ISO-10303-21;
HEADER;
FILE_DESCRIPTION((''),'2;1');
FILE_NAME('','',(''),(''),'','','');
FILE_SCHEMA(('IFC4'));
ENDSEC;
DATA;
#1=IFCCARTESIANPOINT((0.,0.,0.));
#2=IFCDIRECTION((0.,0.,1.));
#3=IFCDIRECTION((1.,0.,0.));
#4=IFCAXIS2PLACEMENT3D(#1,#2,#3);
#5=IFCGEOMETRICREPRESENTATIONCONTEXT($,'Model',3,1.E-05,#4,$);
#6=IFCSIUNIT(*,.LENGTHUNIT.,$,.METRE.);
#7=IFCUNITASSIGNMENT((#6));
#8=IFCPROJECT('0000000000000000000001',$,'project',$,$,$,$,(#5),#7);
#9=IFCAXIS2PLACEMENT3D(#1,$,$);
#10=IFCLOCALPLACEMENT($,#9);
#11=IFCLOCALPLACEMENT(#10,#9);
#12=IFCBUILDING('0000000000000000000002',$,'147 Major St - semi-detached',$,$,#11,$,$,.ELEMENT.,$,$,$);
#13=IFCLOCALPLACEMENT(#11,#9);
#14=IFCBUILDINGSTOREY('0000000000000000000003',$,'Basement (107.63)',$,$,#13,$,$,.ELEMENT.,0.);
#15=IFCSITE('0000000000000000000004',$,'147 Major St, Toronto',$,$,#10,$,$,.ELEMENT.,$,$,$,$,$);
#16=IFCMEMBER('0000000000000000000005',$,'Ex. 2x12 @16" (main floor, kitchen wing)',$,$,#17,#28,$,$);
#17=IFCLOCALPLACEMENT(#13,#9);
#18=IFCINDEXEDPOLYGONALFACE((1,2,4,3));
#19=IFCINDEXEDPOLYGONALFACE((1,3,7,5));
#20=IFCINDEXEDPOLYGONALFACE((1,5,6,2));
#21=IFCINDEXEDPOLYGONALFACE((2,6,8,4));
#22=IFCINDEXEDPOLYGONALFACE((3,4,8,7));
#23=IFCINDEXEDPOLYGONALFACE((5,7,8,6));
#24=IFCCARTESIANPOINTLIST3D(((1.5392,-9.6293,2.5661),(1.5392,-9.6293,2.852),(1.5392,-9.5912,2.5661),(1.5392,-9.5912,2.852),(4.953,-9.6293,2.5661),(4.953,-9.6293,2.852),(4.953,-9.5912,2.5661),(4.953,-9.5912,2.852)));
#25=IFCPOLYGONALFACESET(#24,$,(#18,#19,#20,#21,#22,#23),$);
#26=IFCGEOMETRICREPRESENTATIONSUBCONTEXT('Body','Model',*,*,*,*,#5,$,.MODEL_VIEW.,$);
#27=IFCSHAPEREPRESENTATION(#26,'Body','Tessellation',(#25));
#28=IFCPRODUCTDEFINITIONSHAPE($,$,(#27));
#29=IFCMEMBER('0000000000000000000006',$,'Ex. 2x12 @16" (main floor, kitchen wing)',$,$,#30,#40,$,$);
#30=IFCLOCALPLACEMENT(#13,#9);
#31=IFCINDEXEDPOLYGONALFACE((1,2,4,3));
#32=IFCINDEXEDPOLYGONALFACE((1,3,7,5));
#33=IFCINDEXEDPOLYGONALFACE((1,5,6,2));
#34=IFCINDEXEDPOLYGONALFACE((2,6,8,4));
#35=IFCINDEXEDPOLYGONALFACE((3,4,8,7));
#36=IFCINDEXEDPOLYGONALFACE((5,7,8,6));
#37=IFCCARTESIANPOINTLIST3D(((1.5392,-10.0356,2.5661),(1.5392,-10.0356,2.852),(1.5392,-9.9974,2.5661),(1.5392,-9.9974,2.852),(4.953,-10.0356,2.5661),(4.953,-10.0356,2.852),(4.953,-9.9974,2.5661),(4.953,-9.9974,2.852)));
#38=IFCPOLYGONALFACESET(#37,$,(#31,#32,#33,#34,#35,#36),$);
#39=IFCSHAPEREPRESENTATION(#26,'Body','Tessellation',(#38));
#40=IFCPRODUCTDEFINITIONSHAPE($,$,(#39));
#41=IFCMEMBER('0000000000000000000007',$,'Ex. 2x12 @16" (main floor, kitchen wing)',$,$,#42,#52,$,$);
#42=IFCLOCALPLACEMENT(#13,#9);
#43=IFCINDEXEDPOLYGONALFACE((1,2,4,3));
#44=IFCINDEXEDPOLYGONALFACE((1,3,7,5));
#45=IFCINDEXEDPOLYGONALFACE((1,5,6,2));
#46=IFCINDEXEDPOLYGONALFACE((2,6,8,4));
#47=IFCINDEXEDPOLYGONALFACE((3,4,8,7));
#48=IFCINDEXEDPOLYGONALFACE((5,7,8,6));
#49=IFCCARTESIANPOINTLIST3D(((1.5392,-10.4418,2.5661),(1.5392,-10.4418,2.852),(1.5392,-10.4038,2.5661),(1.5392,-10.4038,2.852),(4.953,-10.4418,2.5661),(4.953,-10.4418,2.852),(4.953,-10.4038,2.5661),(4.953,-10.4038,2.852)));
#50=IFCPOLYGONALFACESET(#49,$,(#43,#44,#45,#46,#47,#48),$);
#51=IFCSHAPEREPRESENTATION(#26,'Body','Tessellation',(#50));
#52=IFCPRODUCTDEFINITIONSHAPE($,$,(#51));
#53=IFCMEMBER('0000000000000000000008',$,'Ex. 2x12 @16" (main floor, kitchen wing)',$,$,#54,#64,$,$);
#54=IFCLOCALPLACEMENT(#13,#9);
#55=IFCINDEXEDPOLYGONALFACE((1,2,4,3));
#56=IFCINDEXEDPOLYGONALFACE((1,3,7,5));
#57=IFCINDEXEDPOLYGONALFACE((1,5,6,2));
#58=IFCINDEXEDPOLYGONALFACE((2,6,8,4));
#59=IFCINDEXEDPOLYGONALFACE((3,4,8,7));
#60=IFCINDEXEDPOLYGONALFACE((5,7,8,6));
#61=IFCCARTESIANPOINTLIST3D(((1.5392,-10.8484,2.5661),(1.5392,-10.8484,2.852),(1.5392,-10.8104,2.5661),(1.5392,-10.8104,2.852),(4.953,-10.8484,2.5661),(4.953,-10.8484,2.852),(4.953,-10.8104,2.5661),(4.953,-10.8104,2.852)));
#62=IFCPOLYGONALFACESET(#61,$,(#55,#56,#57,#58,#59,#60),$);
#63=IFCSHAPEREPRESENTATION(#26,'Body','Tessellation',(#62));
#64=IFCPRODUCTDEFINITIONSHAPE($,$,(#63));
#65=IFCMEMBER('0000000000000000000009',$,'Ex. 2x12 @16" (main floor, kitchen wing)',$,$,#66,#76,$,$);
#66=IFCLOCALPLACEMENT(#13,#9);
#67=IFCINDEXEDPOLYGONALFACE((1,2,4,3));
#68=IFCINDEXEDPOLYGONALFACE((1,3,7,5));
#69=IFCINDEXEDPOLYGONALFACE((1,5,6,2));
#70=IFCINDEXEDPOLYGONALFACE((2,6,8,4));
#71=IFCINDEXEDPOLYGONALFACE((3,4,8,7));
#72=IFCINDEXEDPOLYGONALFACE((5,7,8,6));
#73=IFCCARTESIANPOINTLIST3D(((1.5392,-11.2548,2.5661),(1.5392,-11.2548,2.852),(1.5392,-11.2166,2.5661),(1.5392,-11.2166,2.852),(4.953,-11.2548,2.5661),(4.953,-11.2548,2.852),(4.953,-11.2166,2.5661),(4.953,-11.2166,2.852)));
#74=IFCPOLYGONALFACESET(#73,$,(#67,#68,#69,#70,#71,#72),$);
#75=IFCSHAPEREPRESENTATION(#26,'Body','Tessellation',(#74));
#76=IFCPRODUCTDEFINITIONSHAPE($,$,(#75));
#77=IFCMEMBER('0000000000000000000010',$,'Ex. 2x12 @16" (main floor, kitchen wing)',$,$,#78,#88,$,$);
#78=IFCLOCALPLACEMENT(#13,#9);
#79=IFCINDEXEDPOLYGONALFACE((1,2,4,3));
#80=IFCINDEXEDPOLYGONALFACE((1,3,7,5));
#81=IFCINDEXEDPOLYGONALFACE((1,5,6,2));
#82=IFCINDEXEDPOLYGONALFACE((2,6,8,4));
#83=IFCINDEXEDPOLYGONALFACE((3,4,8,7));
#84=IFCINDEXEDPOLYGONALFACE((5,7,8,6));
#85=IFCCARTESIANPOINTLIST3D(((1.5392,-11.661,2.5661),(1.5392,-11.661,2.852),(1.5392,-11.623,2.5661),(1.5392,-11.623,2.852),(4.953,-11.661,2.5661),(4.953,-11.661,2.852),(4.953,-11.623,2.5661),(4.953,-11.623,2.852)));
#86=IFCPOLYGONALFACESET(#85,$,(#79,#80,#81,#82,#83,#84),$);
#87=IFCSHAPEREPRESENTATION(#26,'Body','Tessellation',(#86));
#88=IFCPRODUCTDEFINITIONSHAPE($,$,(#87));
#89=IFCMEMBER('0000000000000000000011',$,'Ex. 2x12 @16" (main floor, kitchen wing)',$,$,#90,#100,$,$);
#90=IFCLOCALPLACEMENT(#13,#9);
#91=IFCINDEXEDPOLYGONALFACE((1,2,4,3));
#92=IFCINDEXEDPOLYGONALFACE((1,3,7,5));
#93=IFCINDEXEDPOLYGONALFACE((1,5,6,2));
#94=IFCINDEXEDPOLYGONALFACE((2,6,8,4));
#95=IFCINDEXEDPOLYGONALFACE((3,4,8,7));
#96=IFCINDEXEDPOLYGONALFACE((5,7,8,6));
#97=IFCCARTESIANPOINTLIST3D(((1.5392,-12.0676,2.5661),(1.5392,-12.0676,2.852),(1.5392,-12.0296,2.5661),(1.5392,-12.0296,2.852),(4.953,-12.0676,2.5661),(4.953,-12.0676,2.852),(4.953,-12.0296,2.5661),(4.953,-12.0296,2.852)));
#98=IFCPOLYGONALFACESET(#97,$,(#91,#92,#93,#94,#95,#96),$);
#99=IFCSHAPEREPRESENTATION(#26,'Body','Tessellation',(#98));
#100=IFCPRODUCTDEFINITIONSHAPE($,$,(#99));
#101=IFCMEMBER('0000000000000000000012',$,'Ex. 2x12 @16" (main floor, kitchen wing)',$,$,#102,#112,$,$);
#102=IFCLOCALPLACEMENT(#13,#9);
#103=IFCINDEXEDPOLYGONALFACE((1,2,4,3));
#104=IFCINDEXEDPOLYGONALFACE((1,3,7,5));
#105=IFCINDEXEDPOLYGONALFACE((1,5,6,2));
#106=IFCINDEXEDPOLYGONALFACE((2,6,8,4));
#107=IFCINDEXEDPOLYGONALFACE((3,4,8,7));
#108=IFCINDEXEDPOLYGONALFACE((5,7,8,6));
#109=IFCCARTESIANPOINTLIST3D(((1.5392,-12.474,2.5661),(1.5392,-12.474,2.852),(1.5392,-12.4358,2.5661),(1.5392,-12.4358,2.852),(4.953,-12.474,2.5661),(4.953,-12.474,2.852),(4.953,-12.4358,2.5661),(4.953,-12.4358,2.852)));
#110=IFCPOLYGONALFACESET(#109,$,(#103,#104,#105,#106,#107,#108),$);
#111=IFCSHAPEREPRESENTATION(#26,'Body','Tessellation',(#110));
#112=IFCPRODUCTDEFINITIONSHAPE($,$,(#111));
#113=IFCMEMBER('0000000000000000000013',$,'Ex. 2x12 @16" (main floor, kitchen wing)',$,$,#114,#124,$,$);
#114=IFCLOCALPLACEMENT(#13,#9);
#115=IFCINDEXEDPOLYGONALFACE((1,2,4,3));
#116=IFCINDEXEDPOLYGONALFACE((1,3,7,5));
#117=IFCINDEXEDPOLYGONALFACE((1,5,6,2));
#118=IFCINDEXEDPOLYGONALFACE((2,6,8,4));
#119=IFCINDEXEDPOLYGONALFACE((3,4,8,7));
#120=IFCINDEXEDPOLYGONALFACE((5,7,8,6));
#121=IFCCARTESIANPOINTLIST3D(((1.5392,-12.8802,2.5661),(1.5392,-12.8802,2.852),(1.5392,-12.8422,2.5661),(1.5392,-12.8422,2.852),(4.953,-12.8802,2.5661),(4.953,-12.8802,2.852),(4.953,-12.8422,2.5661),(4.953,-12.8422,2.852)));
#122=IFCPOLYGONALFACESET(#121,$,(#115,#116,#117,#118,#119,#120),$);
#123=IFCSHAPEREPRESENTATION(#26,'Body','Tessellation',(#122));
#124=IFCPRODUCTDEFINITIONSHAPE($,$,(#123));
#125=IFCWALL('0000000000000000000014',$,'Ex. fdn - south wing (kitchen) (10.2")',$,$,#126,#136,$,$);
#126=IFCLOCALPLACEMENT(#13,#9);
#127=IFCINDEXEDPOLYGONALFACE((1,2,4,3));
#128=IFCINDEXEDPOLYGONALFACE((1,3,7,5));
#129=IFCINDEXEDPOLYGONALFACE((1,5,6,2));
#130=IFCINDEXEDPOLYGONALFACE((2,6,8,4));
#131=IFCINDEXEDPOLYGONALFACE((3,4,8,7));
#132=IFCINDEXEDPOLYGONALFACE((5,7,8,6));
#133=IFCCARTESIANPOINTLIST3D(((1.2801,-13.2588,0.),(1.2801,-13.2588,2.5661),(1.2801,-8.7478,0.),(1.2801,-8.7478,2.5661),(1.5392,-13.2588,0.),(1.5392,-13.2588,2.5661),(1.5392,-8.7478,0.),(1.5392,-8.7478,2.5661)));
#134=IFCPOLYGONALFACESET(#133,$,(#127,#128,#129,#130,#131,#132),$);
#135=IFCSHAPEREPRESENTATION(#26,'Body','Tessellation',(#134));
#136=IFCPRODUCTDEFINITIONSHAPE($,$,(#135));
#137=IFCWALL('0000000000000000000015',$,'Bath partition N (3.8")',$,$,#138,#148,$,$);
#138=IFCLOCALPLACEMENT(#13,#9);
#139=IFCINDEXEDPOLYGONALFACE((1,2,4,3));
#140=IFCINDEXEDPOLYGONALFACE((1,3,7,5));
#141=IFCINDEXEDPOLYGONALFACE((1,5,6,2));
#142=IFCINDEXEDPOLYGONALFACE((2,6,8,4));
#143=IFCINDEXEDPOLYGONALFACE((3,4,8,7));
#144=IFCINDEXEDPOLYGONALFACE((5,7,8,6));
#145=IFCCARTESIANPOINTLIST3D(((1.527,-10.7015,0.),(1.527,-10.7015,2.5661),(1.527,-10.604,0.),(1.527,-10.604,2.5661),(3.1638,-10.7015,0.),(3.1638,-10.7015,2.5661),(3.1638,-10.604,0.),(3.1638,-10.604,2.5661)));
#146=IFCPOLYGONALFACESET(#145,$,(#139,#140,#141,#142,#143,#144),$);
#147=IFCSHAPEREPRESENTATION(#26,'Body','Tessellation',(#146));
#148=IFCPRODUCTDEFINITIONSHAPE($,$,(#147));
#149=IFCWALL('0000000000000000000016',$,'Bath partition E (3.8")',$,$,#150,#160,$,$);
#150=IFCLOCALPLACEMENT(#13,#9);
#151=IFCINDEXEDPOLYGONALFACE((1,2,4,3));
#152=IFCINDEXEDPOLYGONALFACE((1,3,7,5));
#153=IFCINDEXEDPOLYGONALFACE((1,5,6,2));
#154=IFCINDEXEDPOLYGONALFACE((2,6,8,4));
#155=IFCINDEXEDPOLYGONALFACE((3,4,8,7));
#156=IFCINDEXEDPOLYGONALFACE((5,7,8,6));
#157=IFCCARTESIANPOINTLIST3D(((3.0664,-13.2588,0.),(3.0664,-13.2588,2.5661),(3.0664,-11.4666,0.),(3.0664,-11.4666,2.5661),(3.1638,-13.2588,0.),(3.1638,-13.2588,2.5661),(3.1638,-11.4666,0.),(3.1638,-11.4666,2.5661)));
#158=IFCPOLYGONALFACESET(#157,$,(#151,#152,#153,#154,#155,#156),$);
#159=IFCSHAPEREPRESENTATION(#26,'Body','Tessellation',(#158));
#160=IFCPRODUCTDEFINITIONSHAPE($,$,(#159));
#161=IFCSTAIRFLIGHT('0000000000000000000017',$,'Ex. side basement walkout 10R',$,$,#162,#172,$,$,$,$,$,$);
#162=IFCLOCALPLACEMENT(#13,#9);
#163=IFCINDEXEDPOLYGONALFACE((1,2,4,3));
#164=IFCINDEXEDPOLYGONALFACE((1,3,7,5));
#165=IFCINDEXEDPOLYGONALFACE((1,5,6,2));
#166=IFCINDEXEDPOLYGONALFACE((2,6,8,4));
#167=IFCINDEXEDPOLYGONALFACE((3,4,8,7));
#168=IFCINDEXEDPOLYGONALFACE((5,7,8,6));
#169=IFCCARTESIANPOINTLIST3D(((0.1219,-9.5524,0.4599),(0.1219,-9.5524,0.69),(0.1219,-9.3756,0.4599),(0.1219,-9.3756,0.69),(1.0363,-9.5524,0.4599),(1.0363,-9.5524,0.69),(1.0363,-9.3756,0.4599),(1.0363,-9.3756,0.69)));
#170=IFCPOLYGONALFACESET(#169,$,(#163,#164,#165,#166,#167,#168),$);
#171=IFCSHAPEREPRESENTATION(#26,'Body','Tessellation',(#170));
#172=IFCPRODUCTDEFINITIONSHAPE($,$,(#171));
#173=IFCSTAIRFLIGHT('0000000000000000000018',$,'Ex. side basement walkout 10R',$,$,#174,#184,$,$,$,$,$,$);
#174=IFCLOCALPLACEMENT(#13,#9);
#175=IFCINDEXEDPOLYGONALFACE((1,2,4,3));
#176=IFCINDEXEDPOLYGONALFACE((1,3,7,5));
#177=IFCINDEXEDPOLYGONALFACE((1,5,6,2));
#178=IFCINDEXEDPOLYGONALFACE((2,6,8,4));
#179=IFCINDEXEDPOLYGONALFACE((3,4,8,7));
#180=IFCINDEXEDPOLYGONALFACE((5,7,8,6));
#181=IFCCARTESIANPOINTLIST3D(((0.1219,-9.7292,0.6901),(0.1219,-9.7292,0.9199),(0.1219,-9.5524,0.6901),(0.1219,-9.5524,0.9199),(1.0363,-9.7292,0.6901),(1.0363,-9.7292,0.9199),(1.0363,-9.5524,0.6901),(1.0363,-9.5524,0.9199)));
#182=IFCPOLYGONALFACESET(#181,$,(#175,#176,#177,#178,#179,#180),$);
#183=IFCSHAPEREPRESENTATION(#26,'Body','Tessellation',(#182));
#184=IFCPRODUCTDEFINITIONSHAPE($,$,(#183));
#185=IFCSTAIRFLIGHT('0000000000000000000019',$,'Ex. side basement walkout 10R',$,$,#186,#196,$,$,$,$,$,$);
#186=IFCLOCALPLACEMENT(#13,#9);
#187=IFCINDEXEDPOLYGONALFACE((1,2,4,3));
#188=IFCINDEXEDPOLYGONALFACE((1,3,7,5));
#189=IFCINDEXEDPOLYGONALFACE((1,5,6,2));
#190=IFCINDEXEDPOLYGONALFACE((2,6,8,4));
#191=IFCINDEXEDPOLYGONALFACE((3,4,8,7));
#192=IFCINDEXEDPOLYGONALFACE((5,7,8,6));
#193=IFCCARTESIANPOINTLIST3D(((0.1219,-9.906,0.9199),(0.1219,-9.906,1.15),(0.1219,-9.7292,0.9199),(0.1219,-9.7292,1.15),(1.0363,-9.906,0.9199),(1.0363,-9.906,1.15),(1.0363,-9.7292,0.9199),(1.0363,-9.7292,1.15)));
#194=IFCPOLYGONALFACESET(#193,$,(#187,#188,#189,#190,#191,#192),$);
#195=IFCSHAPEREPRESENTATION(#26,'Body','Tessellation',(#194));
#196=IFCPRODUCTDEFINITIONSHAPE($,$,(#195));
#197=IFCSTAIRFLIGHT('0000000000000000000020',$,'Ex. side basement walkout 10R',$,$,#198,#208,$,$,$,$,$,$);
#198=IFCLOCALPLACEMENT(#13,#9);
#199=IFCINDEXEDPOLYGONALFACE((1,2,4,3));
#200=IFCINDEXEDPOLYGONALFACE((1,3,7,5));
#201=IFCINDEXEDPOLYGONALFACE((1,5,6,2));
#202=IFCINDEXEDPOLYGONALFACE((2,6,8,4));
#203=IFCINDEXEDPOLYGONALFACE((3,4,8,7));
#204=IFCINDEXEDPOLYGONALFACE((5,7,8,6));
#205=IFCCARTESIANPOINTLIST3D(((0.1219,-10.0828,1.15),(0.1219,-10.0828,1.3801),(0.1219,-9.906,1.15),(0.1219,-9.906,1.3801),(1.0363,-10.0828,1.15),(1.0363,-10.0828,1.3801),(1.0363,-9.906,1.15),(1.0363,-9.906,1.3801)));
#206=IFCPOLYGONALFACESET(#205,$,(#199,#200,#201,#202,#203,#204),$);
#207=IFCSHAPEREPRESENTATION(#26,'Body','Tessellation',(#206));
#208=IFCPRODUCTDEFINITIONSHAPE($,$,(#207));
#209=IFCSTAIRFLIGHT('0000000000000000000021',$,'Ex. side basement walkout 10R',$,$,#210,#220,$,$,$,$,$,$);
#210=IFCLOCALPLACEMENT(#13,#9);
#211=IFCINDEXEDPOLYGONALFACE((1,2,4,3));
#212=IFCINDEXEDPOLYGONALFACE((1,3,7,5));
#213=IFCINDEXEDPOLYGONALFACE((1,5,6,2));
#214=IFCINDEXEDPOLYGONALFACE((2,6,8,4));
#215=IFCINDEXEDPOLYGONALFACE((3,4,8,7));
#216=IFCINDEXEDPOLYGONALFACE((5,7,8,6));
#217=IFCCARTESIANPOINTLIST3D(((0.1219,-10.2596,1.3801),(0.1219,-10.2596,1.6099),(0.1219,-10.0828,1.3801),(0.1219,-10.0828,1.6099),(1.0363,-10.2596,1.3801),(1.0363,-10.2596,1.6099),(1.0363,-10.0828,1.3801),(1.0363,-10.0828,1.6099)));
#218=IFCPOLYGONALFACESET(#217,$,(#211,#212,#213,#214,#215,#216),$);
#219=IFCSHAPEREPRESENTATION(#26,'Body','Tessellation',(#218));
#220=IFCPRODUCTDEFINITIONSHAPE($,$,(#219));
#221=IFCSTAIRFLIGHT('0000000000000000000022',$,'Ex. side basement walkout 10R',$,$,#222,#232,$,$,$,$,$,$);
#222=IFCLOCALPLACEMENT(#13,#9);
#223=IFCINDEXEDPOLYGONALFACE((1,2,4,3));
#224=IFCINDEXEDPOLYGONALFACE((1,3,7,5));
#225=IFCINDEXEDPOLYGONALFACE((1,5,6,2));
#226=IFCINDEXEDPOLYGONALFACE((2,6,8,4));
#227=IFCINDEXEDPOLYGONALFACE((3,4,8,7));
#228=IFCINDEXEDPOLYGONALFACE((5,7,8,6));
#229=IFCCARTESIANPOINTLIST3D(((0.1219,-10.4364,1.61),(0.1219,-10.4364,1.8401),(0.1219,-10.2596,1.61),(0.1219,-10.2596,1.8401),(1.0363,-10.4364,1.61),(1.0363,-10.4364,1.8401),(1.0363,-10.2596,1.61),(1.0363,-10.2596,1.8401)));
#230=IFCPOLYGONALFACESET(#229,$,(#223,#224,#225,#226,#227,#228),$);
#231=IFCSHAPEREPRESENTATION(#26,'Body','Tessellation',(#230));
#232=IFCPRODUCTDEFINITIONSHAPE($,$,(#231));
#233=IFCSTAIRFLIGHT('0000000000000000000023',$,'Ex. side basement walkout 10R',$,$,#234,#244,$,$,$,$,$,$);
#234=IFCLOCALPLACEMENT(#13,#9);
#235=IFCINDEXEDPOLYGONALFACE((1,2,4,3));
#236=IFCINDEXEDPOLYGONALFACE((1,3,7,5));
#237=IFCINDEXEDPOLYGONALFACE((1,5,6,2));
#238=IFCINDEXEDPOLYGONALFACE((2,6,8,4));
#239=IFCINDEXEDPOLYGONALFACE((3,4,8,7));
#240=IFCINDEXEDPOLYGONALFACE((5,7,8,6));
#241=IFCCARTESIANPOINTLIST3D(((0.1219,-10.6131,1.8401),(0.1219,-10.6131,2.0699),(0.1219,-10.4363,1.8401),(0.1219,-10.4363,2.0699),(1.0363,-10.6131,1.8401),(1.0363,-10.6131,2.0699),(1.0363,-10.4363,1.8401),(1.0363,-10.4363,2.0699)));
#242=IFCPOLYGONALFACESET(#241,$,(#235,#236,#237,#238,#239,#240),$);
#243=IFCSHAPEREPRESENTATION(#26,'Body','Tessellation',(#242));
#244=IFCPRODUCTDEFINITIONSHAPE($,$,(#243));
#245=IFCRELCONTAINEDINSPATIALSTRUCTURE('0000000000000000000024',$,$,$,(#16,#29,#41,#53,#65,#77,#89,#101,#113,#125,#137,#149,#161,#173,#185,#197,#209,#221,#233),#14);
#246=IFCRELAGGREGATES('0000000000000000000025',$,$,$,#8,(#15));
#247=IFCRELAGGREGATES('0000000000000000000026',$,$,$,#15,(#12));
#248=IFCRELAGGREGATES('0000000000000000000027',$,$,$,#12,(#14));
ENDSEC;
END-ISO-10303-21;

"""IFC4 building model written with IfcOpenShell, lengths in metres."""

from ifc_helpers import new_model, si_unit, frame, origin, origin_with_axes, place, context, subcontext, project, spatial, rectangle, extrude, element, save


model = new_model("IFC4")

# Units and contexts
model_context = context("Model", 3, precision=1e-05, world=origin_with_axes())
body_context = subcontext(model_context, "Body", "Model", "MODEL_VIEW")
ifc_project = project(units=[si_unit("LENGTHUNIT", "METRE")], contexts=[model_context])

# Site, building, storey
site_placement = place(None, origin())
site = spatial("IfcSite", under=ifc_project, at=site_placement, Name="147 Major St, Toronto", CompositionType="ELEMENT")
building_placement = place(site_placement, origin())
building = spatial("IfcBuilding", under=site, at=building_placement, Name="147 Major St - semi-detached", CompositionType="ELEMENT")
storey_placement = place(building_placement, origin())
storey = spatial("IfcBuildingStorey", under=building, at=storey_placement, Name="Basement (107.63)", CompositionType="ELEMENT", Elevation=0.0)

# Members
for number, where, name in (
    (1, (3.2461, -9.6102, 2.5661), "Ex. 2x12 @16\" (main floor, kitchen wing)"),
    (2, (3.2461, -10.0165, 2.5661), "Ex. 2x12 @16\" (main floor, kitchen wing)"),
    (3, (3.2461, -10.4228, 2.5661), "Ex. 2x12 @16\" (main floor, kitchen wing)"),
    (4, (3.2461, -10.8294, 2.5661), "Ex. 2x12 @16\" (main floor, kitchen wing)"),
    (5, (3.2461, -11.2357, 2.5661), "Ex. 2x12 @16\" (main floor, kitchen wing)"),
    (6, (3.2461, -11.642, 2.5661), "Ex. 2x12 @16\" (main floor, kitchen wing)"),
    (7, (3.2461, -12.0486, 2.5661), "Ex. 2x12 @16\" (main floor, kitchen wing)"),
    (8, (3.2461, -12.4549, 2.5661), "Ex. 2x12 @16\" (main floor, kitchen wing)"),
    (9, (3.2461, -12.8612, 2.5661), "Ex. 2x12 @16\" (main floor, kitchen wing)"),
):
    element("IfcMember", number, at=place(storey_placement, frame(where)), inside=storey, Name=name, context=body_context, shape_type="SweptSolid", body=[
        extrude(rectangle(XDim=3.4138, YDim=0.0381), origin_with_axes(), (0.0, 0.0, 1.0), 0.2859),
    ])

# Walls
wall_1_placement = place(storey_placement, frame((1.4097, -11.0033, 0.0)))
element("IfcWall", 10, at=wall_1_placement, inside=storey, Name="Ex. fdn - south wing (kitchen) (10.2\")", context=body_context, shape_type="SweptSolid", body=[
    extrude(rectangle(XDim=0.2591, YDim=4.511), origin_with_axes(), (0.0, 0.0, 1.0), 2.5661),
])
wall_2_placement = place(storey_placement, frame((2.3454, -10.6528, 0.0)))
element("IfcWall", 11, at=wall_2_placement, inside=storey, Name="Bath partition N (3.8\")", context=body_context, shape_type="SweptSolid", body=[
    extrude(rectangle(XDim=1.6368, YDim=0.0975), origin_with_axes(), (0.0, 0.0, 1.0), 2.5661),
])
wall_3_placement = place(storey_placement, frame((3.1151, -12.3627, 0.0)))
element("IfcWall", 12, at=wall_3_placement, inside=storey, Name="Bath partition E (3.8\")", context=body_context, shape_type="SweptSolid", body=[
    extrude(rectangle(XDim=0.0975, YDim=1.7922), origin_with_axes(), (0.0, 0.0, 1.0), 2.5661),
])

# Stair flights
stair_flight_1_placement = place(storey_placement, frame((0.5791, -9.464, 0.4599)))
element("IfcStairFlight", 13, at=stair_flight_1_placement, inside=storey, Name="Ex. side basement walkout 10R", context=body_context, shape_type="SweptSolid", body=[
    extrude(rectangle(XDim=0.9144, YDim=0.1768), origin_with_axes(), (0.0, 0.0, 1.0), 0.2301),
])
stair_flight_2_placement = place(storey_placement, frame((0.5791, -9.6408, 0.6901)))
element("IfcStairFlight", 14, at=stair_flight_2_placement, inside=storey, Name="Ex. side basement walkout 10R", context=body_context, shape_type="SweptSolid", body=[
    extrude(rectangle(XDim=0.9144, YDim=0.1768), origin_with_axes(), (0.0, 0.0, 1.0), 0.2298),
])
for number, where, name in (
    (15, (0.5791, -9.8176, 0.9199), "Ex. side basement walkout 10R"),
    (16, (0.5791, -9.9944, 1.15), "Ex. side basement walkout 10R"),
):
    element("IfcStairFlight", number, at=place(storey_placement, frame(where)), inside=storey, Name=name, context=body_context, shape_type="SweptSolid", body=[
        extrude(rectangle(XDim=0.9144, YDim=0.1768), origin_with_axes(), (0.0, 0.0, 1.0), 0.2301),
    ])
stair_flight_3_placement = place(storey_placement, frame((0.5791, -10.1712, 1.3801)))
element("IfcStairFlight", 17, at=stair_flight_3_placement, inside=storey, Name="Ex. side basement walkout 10R", context=body_context, shape_type="SweptSolid", body=[
    extrude(rectangle(XDim=0.9144, YDim=0.1768), origin_with_axes(), (0.0, 0.0, 1.0), 0.2298),
])
stair_flight_4_placement = place(storey_placement, frame((0.5791, -10.348, 1.61)))
element("IfcStairFlight", 18, at=stair_flight_4_placement, inside=storey, Name="Ex. side basement walkout 10R", context=body_context, shape_type="SweptSolid", body=[
    extrude(rectangle(XDim=0.9144, YDim=0.1768), origin_with_axes(), (0.0, 0.0, 1.0), 0.2301),
])
stair_flight_5_placement = place(storey_placement, frame((0.5791, -10.5247, 1.8401)))
element("IfcStairFlight", 19, at=stair_flight_5_placement, inside=storey, Name="Ex. side basement walkout 10R", context=body_context, shape_type="SweptSolid", body=[
    extrude(rectangle(XDim=0.9144, YDim=0.1768), origin_with_axes(), (0.0, 0.0, 1.0), 0.2298),
])

save(model, "model.ifc")
